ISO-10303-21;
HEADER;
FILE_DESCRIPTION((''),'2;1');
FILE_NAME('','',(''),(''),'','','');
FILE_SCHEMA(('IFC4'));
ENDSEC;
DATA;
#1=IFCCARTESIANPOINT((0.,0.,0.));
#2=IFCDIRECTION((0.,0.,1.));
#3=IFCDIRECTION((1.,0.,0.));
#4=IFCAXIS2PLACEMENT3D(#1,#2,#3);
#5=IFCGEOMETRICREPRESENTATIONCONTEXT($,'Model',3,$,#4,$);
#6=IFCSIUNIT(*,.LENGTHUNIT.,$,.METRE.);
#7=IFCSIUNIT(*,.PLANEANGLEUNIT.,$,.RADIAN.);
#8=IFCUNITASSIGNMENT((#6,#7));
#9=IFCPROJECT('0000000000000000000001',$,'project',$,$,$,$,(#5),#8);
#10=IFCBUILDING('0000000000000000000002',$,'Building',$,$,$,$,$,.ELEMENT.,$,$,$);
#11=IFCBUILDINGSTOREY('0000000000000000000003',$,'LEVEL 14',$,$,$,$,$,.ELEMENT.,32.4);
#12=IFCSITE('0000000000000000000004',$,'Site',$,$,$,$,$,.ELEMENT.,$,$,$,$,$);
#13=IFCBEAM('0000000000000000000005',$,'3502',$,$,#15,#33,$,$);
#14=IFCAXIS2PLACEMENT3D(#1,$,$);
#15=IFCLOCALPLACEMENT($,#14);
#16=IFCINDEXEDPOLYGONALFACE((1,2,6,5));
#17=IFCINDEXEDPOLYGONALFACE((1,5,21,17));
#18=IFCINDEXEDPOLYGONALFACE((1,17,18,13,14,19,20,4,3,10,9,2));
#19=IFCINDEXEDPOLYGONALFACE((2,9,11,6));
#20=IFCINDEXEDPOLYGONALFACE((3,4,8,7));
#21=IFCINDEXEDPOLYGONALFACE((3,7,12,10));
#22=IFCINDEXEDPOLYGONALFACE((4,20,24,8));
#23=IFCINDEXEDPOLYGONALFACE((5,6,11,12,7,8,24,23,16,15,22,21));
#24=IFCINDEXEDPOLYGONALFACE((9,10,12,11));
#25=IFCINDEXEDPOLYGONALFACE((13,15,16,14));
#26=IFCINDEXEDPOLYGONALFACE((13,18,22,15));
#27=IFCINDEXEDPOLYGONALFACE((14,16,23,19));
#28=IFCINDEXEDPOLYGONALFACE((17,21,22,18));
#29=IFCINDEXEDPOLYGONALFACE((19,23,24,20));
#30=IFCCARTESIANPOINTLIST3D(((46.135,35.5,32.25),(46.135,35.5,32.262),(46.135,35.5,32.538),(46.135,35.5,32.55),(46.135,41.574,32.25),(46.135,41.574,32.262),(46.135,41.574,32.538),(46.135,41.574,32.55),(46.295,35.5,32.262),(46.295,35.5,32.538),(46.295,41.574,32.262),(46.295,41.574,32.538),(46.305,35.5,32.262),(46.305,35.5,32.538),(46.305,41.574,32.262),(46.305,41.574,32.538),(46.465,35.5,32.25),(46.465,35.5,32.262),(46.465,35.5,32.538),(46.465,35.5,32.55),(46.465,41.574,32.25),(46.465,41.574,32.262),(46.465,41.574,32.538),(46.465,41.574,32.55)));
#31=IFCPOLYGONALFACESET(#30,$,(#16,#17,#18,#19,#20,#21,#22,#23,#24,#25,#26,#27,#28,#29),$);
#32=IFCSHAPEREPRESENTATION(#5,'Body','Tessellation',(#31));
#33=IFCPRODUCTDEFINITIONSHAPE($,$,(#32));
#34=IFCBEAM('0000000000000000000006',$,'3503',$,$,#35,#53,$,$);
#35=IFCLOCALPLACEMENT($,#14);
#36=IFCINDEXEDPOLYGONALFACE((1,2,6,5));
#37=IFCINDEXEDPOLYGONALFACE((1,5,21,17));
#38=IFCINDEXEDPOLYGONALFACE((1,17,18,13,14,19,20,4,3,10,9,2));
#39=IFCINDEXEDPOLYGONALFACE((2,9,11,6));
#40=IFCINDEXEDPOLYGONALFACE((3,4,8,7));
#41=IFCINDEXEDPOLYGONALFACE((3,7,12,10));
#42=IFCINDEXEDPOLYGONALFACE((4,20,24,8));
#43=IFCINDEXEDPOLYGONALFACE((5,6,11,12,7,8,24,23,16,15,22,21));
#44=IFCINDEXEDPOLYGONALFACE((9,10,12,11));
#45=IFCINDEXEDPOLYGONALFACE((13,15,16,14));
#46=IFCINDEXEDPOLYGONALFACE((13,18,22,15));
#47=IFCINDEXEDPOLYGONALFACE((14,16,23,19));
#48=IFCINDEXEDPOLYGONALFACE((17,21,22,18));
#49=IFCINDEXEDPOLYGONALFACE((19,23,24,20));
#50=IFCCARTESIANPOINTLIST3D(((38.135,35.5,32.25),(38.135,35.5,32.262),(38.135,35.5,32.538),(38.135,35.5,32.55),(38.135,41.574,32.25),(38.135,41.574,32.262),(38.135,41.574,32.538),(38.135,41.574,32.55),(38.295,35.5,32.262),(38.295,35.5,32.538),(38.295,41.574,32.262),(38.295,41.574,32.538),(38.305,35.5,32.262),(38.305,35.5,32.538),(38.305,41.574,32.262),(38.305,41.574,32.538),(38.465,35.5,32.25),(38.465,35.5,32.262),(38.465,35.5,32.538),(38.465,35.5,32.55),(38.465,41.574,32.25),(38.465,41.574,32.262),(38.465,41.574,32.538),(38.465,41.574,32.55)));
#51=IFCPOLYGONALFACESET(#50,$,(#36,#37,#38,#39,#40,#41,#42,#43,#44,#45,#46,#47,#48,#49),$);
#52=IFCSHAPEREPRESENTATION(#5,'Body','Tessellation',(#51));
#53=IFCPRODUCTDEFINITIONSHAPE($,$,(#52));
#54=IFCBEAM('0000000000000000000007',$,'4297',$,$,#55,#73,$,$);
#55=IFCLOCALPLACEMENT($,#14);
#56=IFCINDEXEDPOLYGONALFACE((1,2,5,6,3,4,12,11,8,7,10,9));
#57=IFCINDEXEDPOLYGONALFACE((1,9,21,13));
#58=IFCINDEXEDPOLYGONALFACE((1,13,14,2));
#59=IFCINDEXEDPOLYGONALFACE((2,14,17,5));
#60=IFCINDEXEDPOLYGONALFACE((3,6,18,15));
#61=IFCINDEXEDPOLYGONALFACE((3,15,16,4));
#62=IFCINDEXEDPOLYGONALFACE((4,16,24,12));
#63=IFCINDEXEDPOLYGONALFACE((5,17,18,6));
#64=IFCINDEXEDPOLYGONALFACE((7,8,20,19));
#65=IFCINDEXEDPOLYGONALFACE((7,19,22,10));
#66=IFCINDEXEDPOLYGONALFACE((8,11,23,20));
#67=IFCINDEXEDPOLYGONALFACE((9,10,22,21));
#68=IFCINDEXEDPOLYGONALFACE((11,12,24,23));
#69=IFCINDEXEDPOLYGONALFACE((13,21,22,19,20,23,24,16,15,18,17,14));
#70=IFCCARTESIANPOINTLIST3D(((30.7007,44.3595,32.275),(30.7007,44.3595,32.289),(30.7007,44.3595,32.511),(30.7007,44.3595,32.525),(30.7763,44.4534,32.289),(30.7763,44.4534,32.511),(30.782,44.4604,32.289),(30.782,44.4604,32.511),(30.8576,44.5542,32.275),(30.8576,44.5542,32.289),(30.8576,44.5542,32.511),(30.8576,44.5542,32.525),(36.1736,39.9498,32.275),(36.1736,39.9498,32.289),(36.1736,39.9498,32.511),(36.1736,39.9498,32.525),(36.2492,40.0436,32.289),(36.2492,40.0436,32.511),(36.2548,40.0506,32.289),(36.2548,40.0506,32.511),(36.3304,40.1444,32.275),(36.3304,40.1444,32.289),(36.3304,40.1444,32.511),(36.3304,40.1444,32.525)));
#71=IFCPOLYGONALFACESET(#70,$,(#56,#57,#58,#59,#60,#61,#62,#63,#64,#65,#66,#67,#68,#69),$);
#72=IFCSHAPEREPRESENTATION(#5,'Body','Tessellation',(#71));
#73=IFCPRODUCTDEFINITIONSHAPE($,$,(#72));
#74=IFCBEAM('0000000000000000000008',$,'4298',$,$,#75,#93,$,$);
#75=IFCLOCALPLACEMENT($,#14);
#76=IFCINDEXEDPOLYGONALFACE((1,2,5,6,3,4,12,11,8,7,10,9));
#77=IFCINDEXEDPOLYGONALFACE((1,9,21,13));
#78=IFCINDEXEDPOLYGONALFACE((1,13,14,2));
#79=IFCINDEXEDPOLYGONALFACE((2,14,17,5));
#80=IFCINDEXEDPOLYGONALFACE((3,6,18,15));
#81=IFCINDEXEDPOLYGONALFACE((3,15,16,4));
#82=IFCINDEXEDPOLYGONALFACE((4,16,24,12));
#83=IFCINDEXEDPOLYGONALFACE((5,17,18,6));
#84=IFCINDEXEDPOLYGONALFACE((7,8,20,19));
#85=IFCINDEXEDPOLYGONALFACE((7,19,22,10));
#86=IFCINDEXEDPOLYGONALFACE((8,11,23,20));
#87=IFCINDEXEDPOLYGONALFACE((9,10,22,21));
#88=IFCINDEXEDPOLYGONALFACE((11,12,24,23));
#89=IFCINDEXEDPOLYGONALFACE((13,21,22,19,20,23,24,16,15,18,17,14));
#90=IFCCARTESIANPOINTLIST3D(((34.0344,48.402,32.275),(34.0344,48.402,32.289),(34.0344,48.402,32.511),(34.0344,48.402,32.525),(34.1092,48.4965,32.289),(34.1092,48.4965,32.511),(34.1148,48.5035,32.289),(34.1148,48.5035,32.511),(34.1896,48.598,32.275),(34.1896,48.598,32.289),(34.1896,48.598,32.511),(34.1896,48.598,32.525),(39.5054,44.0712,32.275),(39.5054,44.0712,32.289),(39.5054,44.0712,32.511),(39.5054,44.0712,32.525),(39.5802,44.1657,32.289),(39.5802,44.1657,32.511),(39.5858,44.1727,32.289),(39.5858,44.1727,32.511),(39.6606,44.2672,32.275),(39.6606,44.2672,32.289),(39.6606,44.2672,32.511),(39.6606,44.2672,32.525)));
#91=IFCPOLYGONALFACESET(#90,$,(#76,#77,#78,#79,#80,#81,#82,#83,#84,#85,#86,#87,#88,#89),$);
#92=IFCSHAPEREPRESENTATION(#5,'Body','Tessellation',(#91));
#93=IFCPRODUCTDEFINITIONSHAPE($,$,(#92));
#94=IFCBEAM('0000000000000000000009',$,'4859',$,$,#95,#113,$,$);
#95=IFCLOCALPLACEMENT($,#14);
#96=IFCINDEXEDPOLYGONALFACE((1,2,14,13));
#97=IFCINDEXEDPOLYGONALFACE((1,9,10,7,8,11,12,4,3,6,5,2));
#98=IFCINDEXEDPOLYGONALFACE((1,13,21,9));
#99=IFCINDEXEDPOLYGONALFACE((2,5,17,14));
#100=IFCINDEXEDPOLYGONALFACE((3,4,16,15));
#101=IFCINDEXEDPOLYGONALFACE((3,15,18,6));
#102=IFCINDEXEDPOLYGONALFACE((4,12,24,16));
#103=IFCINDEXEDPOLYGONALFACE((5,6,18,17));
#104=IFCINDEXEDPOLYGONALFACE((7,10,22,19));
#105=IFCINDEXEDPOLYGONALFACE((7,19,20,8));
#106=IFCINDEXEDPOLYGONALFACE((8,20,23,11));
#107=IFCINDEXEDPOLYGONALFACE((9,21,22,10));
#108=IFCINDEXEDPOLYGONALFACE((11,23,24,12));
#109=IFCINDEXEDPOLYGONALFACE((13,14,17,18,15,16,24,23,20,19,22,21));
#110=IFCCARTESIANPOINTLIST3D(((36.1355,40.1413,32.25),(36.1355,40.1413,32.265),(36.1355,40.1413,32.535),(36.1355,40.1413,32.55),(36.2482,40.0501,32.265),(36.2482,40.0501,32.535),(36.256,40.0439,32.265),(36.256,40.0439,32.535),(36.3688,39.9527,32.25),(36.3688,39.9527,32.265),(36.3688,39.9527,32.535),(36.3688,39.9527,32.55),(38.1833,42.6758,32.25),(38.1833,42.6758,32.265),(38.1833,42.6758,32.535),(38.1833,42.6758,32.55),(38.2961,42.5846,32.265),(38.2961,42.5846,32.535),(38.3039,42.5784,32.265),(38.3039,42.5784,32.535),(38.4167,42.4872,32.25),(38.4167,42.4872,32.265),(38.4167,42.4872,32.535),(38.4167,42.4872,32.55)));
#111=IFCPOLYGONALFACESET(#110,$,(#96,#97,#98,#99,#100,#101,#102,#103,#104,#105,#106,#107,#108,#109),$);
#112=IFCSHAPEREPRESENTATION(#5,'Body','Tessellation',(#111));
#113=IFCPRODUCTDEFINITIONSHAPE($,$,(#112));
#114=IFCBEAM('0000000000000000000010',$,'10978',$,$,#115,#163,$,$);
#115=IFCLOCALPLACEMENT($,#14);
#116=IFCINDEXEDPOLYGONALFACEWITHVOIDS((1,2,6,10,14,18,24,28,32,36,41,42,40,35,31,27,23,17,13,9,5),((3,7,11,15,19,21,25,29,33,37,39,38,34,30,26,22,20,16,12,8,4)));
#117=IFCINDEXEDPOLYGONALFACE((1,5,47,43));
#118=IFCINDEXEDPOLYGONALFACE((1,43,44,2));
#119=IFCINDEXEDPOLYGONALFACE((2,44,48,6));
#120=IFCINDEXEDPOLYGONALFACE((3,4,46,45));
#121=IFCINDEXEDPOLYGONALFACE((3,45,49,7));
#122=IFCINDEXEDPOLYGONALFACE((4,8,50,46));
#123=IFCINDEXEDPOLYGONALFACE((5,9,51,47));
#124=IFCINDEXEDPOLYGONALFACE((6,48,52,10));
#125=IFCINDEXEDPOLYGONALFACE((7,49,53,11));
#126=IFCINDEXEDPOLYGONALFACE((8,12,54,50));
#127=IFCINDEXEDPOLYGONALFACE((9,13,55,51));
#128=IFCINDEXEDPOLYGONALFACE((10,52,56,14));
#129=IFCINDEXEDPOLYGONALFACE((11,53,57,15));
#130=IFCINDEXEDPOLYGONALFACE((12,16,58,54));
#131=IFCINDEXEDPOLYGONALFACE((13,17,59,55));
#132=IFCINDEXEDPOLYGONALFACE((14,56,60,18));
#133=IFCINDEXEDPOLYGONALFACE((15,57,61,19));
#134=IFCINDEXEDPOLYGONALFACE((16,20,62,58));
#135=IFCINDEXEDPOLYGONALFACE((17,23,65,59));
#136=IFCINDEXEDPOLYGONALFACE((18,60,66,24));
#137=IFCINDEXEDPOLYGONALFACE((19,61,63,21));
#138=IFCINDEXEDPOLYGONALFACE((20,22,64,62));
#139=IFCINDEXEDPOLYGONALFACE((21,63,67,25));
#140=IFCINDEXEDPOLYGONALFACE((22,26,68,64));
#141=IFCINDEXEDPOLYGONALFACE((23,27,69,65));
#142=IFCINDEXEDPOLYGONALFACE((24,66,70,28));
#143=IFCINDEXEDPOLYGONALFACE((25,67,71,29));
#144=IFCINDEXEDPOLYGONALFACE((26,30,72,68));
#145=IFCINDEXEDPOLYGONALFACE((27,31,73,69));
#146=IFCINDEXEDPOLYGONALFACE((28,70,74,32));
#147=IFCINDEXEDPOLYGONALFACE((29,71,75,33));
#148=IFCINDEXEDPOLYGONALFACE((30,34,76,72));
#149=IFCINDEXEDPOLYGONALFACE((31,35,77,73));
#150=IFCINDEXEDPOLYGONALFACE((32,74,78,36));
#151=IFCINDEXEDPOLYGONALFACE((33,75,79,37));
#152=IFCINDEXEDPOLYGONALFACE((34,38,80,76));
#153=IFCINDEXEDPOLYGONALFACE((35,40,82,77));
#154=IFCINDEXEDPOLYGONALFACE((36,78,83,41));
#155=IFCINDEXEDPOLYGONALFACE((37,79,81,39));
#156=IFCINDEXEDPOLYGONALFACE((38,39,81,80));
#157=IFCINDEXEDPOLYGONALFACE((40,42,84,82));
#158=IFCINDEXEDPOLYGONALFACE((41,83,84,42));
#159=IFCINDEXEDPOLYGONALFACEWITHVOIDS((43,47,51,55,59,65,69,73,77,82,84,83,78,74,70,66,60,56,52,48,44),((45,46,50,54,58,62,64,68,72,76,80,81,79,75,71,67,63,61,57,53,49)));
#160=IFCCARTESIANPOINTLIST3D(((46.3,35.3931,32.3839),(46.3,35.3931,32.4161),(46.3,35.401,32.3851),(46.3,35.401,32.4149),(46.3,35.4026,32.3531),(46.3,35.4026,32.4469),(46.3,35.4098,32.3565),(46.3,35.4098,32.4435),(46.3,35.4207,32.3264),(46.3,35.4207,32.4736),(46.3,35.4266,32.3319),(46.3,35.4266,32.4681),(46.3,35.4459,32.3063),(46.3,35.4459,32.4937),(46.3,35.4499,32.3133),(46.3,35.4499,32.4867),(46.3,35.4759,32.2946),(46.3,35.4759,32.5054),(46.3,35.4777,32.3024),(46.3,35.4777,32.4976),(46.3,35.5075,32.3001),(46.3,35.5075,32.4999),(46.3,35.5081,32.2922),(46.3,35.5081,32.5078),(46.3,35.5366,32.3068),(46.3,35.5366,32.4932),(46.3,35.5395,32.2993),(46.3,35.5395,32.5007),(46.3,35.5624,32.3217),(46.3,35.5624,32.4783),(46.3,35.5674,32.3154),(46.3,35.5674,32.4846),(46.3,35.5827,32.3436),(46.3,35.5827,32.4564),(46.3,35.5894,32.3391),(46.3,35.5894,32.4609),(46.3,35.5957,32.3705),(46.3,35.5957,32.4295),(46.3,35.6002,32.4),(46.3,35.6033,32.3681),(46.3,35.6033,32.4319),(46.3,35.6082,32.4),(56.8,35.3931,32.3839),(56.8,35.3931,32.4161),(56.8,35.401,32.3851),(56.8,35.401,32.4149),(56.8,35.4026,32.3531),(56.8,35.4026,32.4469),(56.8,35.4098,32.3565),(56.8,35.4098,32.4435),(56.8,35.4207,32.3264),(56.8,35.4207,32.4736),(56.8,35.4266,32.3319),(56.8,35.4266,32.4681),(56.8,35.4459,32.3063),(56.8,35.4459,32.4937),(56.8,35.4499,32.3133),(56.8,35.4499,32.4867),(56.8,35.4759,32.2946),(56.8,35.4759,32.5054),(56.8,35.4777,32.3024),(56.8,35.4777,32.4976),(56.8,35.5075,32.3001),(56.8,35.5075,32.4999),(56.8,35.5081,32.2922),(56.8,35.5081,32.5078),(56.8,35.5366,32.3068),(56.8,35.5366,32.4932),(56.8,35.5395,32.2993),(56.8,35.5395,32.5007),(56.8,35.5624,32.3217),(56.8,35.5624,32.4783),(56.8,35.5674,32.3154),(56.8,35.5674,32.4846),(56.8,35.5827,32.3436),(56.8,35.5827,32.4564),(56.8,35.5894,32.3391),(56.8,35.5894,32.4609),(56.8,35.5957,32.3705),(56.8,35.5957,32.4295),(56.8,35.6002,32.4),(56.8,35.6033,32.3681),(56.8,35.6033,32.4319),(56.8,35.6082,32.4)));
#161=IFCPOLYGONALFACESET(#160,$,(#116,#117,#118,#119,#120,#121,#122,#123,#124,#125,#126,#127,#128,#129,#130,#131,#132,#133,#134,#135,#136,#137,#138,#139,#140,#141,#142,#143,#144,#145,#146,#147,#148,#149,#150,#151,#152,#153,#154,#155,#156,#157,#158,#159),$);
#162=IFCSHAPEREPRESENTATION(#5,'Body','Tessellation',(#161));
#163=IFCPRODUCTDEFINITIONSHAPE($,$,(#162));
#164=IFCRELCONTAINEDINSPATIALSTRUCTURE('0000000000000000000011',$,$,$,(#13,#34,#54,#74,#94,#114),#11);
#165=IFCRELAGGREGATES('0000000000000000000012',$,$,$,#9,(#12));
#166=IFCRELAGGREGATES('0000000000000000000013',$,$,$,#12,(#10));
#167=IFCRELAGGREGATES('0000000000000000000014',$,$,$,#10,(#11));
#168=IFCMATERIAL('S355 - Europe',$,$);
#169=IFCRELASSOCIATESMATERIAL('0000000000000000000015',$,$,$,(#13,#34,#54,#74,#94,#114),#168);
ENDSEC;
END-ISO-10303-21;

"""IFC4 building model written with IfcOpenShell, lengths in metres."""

from ifc_helpers import new_model, si_unit, frame, origin_with_axes, origin_2d_with_axis, place, context, project, spatial, hollow_circle, i_section, extrude, material, material_profile, profile_set, profile_usage, element, save


model = new_model("IFC4")

# Units and contexts
model_context = context("Model", 3, world=origin_with_axes())
ifc_project = project(units=[si_unit("LENGTHUNIT", "METRE"), si_unit("PLANEANGLEUNIT", "RADIAN")], contexts=[model_context])

# Site, building, storey
site = spatial("IfcSite", under=ifc_project, Name="Site", CompositionType="ELEMENT")
building = spatial("IfcBuilding", under=site, Name="Building", CompositionType="ELEMENT")
storey = spatial("IfcBuildingStorey", under=building, Name="LEVEL 14", CompositionType="ELEMENT", Elevation=32.4)

# Shared definitions
ifc_material = material(Name="S355 - Europe")

# Beams
ifc_material_profile_1 = material_profile(ifc_material, i_section(OverallWidth=0.33, OverallDepth=0.3, WebThickness=0.01, FlangeThickness=0.012, at=origin_2d_with_axis()))
ifc_profile_set_1 = profile_set([ifc_material_profile_1])
ifc_profile_usage_1 = profile_usage(ifc_profile_set_1, cardinal=10)
beam_1_placement = place(None, frame((46.3, 41.574, 32.4), z_axis=(0.0, -1.0, 0.0), x_axis=(1.0, 0.0, 0.0)))
element("IfcBeam", 1, at=beam_1_placement, inside=storey, material=ifc_profile_usage_1, Name="3502", context=model_context, shape_type="SweptSolid", body=[
    extrude(i_section(OverallWidth=0.33, OverallDepth=0.3, WebThickness=0.01, FlangeThickness=0.012, at=origin_2d_with_axis()), origin_with_axes(), (0.0, 0.0, 1.0), 6.074),
])
ifc_material_profile_2 = material_profile(ifc_material, i_section(OverallWidth=0.33, OverallDepth=0.3, WebThickness=0.01, FlangeThickness=0.012, at=origin_2d_with_axis()))
ifc_profile_set_2 = profile_set([ifc_material_profile_2])
ifc_profile_usage_2 = profile_usage(ifc_profile_set_2, cardinal=10)
beam_2_placement = place(None, frame((38.3, 41.574, 32.4), z_axis=(0.0, -1.0, 0.0), x_axis=(1.0, 0.0, 0.0)))
element("IfcBeam", 2, at=beam_2_placement, inside=storey, material=ifc_profile_usage_2, Name="3503", context=model_context, shape_type="SweptSolid", body=[
    extrude(i_section(OverallWidth=0.33, OverallDepth=0.3, WebThickness=0.01, FlangeThickness=0.012, at=origin_2d_with_axis()), origin_with_axes(), (0.0, 0.0, 1.0), 6.074),
])
ifc_material_profile_3 = material_profile(ifc_material, i_section(OverallWidth=0.25, OverallDepth=0.25, WebThickness=0.009, FlangeThickness=0.014, at=origin_2d_with_axis()))
ifc_profile_set_3 = profile_set([ifc_material_profile_3])
ifc_profile_usage_3 = profile_usage(ifc_profile_set_3, cardinal=10)
beam_3_placement = place(None, frame((36.252, 40.0471, 32.4), z_axis=(-0.77868, 0.627421, 0.0), x_axis=(-0.627421, -0.77868, 0.0)))
element("IfcBeam", 3, at=beam_3_placement, inside=storey, material=ifc_profile_usage_3, Name="4297", context=model_context, shape_type="SweptSolid", body=[
    extrude(i_section(OverallWidth=0.25, OverallDepth=0.25, WebThickness=0.009, FlangeThickness=0.014, at=origin_2d_with_axis()), origin_with_axes(), (0.0, 0.0, 1.0), 7.0284),
])
ifc_material_profile_4 = material_profile(ifc_material, i_section(OverallWidth=0.25, OverallDepth=0.25, WebThickness=0.009, FlangeThickness=0.014, at=origin_2d_with_axis()))
ifc_profile_set_4 = profile_set([ifc_material_profile_4])
ifc_profile_usage_4 = profile_usage(ifc_profile_set_4, cardinal=10)
beam_4_placement = place(None, frame((39.583, 44.1692, 32.4), z_axis=(-0.784074, 0.620667, 0.0), x_axis=(-0.620667, -0.784074, 0.0)))
element("IfcBeam", 4, at=beam_4_placement, inside=storey, material=ifc_profile_usage_4, Name="4298", context=model_context, shape_type="SweptSolid", body=[
    extrude(i_section(OverallWidth=0.25, OverallDepth=0.25, WebThickness=0.009, FlangeThickness=0.014, at=origin_2d_with_axis()), origin_with_axes(), (0.0, 0.0, 1.0), 6.9777),
])
ifc_material_profile_5 = material_profile(ifc_material, i_section(OverallWidth=0.3, OverallDepth=0.3, WebThickness=0.01, FlangeThickness=0.015, at=origin_2d_with_axis()))
ifc_profile_set_5 = profile_set([ifc_material_profile_5])
ifc_profile_usage_5 = profile_usage(ifc_profile_set_5, cardinal=10)
beam_5_placement = place(None, frame((38.3, 42.5815, 32.4), z_axis=(-0.62848, -0.777826, 0.0), x_axis=(0.777711, -0.628621, 0.0)))
element("IfcBeam", 5, at=beam_5_placement, inside=storey, material=ifc_profile_usage_5, Name="4859", context=model_context, shape_type="SweptSolid", body=[
    extrude(i_section(OverallWidth=0.3, OverallDepth=0.3, WebThickness=0.01, FlangeThickness=0.015, at=origin_2d_with_axis()), origin_with_axes(), (0.0, 0.0, 1.0), 3.2584),
])
ifc_material_profile_6 = material_profile(ifc_material, hollow_circle(Radius=0.1081, WallThickness=0.008, at=origin_2d_with_axis()))
ifc_profile_set_6 = profile_set([ifc_material_profile_6])
ifc_profile_usage_6 = profile_usage(ifc_profile_set_6, cardinal=10)
beam_6_placement = place(None, frame((46.3, 35.5, 32.4), z_axis=(1.0, 0.0, 0.0), x_axis=(0.0, 1.0, 0.0)))
element("IfcBeam", 6, at=beam_6_placement, inside=storey, material=ifc_profile_usage_6, Name="10978", context=model_context, shape_type="SweptSolid", body=[
    extrude(hollow_circle(Radius=0.1081, WallThickness=0.008, at=origin_2d_with_axis()), origin_with_axes(), (0.0, 0.0, 1.0), 10.5),
])

save(model, "model.ifc")
